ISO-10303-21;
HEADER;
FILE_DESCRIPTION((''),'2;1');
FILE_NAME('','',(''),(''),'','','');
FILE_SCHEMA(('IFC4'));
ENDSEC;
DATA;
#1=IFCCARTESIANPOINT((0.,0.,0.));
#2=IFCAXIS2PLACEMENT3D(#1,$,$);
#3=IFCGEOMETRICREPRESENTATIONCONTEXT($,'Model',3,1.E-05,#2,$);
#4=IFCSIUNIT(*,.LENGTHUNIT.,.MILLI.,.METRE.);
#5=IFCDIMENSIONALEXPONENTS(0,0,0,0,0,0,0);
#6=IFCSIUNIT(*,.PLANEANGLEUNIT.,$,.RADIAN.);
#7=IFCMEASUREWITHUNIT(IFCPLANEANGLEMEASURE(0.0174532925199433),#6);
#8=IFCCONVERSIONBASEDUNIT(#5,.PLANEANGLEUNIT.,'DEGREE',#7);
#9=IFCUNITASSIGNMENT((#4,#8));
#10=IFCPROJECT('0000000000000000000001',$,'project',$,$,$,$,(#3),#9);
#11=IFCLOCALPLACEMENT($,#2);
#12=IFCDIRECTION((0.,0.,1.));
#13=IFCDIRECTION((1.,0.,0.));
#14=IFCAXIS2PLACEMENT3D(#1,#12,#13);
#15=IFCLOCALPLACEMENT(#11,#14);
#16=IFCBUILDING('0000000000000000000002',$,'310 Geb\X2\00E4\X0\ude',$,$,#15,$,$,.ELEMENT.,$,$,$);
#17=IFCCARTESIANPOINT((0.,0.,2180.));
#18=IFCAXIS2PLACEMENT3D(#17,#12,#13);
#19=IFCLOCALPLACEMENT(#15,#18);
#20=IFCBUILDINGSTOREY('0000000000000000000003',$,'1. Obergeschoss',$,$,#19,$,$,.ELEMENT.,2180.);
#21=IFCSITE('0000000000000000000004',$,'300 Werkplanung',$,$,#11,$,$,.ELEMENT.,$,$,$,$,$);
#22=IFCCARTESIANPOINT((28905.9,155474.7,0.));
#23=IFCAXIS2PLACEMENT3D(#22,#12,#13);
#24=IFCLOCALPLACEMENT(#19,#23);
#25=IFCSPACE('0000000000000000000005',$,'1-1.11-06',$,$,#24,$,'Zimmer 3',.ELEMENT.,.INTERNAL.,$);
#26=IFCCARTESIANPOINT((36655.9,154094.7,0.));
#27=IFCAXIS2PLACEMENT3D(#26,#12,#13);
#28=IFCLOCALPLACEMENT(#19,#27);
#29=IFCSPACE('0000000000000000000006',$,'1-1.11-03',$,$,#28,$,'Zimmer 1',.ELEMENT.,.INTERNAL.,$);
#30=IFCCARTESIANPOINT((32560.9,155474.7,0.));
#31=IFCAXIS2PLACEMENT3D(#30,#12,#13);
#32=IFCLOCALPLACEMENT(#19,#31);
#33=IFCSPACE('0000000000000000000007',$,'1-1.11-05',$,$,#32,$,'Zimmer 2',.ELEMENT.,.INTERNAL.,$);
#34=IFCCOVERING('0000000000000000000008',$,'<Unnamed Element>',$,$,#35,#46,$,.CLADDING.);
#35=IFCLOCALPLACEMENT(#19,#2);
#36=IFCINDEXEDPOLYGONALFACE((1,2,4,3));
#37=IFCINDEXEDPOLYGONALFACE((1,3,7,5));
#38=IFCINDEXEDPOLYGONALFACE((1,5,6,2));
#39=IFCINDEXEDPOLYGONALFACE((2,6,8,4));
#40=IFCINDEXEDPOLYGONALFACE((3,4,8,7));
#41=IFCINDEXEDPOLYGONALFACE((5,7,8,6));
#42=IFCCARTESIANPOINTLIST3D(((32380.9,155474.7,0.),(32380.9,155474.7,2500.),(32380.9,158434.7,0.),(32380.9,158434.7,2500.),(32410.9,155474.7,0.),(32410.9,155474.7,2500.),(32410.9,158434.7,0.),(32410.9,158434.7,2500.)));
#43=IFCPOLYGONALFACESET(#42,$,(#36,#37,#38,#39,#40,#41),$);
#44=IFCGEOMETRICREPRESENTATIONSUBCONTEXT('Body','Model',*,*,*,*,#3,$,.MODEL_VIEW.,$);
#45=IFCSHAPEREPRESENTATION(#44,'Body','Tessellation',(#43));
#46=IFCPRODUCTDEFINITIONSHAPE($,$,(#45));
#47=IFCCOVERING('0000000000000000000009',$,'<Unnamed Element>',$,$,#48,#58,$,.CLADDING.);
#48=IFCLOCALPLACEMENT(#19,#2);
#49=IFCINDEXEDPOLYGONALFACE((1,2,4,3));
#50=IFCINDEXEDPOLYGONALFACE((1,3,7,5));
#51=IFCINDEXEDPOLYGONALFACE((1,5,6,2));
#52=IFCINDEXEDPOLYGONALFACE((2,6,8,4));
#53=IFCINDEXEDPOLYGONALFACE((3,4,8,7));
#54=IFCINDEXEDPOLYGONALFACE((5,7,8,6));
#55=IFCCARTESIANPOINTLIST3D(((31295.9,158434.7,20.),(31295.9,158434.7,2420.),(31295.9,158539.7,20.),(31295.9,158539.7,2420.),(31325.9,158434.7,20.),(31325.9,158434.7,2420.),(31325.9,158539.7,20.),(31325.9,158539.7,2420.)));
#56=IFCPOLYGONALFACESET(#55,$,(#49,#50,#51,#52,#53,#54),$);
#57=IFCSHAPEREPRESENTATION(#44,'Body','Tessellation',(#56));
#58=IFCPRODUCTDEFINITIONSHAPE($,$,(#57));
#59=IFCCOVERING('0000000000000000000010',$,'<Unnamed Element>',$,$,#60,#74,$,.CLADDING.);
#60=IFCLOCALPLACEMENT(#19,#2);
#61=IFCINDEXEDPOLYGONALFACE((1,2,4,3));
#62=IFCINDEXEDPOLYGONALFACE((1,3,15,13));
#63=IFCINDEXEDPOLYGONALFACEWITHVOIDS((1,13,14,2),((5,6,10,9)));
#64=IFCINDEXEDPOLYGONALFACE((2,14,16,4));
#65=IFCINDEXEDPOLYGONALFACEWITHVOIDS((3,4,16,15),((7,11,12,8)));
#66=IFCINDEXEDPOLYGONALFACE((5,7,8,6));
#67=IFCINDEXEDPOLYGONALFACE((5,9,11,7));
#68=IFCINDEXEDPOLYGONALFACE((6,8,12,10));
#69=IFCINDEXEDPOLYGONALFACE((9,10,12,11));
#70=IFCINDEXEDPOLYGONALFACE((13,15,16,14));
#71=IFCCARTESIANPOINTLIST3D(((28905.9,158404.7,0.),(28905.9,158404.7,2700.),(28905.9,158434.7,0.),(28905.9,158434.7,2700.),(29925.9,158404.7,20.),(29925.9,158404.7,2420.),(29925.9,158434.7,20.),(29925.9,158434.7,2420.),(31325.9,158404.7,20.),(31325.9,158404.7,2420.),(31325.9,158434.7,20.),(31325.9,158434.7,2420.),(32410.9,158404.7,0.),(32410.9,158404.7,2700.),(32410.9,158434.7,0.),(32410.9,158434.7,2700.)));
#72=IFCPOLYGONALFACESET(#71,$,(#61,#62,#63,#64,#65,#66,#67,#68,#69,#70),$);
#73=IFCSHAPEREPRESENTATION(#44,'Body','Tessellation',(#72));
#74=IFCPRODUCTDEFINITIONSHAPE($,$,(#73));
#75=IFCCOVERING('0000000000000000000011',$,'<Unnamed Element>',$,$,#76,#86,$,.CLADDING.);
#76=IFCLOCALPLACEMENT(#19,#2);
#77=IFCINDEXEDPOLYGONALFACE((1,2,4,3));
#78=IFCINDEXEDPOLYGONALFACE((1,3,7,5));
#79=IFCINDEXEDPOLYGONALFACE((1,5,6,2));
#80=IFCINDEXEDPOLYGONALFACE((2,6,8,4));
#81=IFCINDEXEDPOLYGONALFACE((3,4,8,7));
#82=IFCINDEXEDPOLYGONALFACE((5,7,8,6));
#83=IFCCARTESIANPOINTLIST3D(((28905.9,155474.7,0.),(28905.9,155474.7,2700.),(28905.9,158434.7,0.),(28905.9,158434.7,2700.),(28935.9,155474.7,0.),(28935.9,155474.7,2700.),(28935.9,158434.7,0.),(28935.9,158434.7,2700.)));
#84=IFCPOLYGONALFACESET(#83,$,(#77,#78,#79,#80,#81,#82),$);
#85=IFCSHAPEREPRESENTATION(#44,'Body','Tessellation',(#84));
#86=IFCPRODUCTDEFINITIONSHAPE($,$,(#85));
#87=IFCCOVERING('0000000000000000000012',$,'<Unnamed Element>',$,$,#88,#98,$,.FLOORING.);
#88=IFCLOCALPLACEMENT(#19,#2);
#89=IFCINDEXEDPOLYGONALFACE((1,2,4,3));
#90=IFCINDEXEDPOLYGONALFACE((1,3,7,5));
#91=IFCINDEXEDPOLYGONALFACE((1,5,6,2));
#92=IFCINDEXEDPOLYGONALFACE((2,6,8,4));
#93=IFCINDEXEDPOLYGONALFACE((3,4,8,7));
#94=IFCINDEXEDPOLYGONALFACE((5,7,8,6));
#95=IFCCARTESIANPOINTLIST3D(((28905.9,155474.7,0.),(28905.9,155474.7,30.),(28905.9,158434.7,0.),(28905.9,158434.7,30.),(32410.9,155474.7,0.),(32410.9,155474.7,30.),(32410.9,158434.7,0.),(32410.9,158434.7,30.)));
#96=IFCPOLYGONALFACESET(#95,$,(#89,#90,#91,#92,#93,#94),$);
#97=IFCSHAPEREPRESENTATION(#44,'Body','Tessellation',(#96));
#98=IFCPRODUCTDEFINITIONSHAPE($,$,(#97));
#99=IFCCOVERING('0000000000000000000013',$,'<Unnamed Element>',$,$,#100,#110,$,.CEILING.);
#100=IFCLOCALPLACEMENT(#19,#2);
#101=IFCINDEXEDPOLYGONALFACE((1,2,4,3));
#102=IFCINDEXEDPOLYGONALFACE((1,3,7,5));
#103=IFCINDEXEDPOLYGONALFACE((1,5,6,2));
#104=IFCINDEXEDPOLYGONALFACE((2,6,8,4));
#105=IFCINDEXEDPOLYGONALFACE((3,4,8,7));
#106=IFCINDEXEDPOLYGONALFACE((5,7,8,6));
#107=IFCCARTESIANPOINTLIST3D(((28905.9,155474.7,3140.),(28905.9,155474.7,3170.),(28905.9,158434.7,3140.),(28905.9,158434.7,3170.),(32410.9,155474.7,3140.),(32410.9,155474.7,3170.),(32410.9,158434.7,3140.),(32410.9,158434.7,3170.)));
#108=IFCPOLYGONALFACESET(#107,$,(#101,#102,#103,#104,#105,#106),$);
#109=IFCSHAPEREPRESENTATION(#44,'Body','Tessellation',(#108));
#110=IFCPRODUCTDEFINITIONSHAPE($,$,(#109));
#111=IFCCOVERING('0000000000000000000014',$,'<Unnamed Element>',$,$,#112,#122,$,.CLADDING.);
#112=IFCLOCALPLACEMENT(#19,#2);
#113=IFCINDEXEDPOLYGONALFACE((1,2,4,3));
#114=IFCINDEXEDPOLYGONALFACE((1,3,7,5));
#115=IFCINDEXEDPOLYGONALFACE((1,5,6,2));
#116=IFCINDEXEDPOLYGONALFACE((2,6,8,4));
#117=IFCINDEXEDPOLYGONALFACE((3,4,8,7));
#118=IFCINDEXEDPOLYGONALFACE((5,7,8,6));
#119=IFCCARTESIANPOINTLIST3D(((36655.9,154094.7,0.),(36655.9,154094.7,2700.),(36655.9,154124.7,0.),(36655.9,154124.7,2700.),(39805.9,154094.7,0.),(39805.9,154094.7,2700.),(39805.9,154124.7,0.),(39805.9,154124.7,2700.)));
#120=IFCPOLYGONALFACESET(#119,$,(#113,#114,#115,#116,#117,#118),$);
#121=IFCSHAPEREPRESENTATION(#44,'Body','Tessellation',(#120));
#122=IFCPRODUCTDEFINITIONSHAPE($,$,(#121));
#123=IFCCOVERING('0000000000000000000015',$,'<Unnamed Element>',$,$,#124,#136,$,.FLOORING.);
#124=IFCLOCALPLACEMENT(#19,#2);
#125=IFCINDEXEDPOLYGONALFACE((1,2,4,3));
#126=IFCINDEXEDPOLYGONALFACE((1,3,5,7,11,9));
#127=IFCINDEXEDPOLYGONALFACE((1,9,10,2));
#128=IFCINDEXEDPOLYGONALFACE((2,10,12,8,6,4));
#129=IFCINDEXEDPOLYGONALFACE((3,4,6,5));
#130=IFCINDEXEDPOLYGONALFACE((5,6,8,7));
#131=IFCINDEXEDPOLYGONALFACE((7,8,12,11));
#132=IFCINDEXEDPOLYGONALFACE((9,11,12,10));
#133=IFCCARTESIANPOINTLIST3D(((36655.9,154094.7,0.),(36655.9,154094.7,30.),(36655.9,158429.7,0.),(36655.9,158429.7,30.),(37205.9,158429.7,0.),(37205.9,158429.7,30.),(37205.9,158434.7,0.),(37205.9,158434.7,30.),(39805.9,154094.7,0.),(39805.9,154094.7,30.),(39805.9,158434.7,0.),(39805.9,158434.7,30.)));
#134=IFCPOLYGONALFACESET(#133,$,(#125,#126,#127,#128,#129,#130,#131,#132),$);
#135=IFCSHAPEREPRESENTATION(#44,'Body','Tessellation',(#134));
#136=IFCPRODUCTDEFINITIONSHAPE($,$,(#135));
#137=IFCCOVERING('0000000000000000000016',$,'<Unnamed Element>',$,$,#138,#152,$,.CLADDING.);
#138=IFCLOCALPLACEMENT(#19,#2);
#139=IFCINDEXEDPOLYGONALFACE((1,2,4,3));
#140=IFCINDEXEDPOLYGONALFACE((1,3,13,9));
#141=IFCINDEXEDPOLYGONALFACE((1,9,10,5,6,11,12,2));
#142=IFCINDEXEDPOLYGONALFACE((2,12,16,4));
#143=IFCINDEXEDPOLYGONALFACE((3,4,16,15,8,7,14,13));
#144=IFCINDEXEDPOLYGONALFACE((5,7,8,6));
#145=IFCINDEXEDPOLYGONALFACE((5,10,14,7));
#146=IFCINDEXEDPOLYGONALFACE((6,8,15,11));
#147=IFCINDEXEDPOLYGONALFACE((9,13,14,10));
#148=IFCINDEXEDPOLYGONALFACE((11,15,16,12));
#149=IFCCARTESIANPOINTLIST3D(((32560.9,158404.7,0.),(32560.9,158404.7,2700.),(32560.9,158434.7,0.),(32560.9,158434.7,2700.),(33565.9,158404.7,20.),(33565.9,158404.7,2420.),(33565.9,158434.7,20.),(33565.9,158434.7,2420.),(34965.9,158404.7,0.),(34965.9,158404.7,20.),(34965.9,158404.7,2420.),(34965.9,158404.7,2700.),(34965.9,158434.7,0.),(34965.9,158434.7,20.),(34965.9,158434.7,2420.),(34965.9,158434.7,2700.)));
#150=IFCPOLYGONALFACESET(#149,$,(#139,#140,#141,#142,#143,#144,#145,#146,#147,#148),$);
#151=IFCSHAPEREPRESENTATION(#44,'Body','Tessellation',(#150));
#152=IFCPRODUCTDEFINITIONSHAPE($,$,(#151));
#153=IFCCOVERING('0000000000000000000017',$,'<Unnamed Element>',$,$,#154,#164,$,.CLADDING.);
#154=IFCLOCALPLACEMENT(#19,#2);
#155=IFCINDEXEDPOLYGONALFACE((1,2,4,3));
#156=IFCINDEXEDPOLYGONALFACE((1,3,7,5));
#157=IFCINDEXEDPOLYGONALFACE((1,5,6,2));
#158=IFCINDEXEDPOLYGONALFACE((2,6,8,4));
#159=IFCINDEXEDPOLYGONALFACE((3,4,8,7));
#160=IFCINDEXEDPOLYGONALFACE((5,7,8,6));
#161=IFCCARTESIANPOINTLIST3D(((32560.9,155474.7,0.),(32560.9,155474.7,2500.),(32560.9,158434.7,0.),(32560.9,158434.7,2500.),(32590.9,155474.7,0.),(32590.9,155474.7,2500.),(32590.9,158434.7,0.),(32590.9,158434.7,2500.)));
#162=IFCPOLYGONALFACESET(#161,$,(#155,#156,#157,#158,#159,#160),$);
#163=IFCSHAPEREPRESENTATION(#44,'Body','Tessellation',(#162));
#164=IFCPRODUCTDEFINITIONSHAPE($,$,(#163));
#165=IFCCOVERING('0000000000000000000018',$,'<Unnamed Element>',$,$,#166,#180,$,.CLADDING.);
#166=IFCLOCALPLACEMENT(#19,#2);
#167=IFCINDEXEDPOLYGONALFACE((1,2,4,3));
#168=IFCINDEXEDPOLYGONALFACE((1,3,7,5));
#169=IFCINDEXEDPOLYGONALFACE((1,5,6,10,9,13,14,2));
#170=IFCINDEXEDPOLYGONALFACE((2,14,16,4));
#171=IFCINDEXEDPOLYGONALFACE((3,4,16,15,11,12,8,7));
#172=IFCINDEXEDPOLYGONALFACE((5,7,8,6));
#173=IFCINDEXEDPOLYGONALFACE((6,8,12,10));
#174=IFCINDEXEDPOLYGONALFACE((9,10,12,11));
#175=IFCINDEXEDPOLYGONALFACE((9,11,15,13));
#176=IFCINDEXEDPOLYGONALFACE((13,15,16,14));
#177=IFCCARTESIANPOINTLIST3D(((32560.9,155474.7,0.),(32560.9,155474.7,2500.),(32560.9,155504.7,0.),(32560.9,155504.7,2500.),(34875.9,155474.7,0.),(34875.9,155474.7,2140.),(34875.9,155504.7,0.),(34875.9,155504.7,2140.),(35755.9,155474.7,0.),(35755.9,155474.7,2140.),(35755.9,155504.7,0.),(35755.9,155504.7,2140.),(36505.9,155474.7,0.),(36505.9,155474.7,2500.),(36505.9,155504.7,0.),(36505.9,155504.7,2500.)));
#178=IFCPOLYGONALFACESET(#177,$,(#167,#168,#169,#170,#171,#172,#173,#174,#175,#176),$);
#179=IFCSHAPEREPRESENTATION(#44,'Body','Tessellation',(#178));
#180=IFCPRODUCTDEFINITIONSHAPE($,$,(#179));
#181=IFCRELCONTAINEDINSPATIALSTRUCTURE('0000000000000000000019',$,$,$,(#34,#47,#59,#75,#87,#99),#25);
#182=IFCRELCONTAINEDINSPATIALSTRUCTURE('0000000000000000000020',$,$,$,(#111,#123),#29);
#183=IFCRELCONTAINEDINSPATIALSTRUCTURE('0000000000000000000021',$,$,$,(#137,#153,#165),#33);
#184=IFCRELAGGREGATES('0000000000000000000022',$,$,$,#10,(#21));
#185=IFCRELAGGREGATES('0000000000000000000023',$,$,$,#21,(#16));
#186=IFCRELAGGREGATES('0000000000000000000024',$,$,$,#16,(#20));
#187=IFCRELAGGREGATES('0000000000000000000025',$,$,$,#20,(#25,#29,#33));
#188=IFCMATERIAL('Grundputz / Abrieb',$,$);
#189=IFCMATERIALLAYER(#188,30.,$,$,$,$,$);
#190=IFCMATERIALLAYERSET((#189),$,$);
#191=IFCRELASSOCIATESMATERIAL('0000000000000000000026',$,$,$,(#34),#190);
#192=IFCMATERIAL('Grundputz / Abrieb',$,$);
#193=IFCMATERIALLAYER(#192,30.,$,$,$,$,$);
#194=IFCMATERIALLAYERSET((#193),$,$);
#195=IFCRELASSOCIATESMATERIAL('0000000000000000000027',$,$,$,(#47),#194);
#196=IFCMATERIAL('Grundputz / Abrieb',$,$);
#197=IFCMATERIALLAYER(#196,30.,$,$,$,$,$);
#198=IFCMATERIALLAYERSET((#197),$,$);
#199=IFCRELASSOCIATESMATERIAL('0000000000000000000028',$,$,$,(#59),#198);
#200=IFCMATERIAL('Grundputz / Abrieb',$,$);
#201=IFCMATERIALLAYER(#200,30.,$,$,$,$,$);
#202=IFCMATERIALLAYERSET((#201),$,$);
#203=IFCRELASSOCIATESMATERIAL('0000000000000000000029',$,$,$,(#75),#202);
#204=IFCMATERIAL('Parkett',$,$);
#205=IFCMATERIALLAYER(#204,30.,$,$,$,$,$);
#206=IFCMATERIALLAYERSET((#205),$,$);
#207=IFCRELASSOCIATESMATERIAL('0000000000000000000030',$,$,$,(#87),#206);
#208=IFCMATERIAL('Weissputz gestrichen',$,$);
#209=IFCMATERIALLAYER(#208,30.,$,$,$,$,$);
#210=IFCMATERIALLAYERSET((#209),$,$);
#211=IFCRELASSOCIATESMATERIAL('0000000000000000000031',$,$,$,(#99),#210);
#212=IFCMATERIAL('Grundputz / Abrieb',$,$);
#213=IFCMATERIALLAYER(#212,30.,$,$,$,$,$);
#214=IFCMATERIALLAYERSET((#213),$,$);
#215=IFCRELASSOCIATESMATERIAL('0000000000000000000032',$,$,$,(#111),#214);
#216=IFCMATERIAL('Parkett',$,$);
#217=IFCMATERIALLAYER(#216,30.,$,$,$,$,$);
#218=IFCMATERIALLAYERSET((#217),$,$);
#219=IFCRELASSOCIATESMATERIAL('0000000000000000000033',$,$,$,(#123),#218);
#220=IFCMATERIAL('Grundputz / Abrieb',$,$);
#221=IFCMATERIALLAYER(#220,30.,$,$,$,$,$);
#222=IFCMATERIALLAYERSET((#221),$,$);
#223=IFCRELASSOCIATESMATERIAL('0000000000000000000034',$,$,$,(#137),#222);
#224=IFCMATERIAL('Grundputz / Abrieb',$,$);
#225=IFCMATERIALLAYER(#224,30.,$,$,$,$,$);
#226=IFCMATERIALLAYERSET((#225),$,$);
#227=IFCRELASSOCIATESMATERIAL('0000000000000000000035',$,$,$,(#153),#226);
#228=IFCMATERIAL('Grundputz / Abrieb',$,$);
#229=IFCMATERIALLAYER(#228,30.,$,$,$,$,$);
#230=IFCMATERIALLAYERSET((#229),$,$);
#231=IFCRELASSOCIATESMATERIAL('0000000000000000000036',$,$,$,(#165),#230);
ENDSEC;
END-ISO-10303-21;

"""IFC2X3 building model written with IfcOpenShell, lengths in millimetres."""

from ifc_helpers import new_model, entity, si_unit, converted_unit, frame, frame_2d, origin, origin_with_axes, place, context, subcontext, project, spatial, polyline, rectangle, outline, extrude, material, layer, layer_set, layer_usage, element, save


model = new_model("IFC2X3")

# Units and contexts
model_context = context("Model", 3, precision=1e-05, world=origin())
body_context = subcontext(model_context, "Body", "Model", "MODEL_VIEW")
ifc_project = project(units=[si_unit("LENGTHUNIT", "METRE", prefix="MILLI"), converted_unit("PLANEANGLEUNIT", "DEGREE", entity("IfcPlaneAngleMeasure", 0.0174532925199433), si_unit("PLANEANGLEUNIT", "RADIAN"), dimensions=[0, 0, 0, 0, 0, 0, 0])], contexts=[model_context])

# Site, building, storey
site_placement = place(None, origin())
site = spatial("IfcSite", under=ifc_project, at=site_placement, Name="300 Werkplanung", CompositionType="ELEMENT")
building_placement = place(site_placement, origin_with_axes())
building = spatial("IfcBuilding", under=site, at=building_placement, Name="310 Gebäude", CompositionType="ELEMENT")
storey_placement = place(building_placement, frame((0.0, 0.0, 2180.0), z_axis=(0.0, 0.0, 1.0), x_axis=(1.0, 0.0, 0.0)))
storey = spatial("IfcBuildingStorey", under=building, at=storey_placement, Name="1. Obergeschoss", CompositionType="ELEMENT", Elevation=2180.0)

# Shared definitions
space_1_placement = place(storey_placement, frame((28905.9, 155474.7, 0.0), z_axis=(0.0, 0.0, 1.0), x_axis=(1.0, 0.0, 0.0)))
space_1 = spatial("IfcSpace", under=storey, at=space_1_placement, Name="1-1.11-06", LongName="Zimmer 3", CompositionType="ELEMENT", InteriorOrExteriorSpace="INTERNAL")

# Coverings
ifc_material_1 = material(Name="Grundputz / Abrieb")
ifc_layer_1 = layer(ifc_material_1, 30.0)
ifc_layer_set_1 = layer_set([ifc_layer_1])
ifc_layer_usage_1 = layer_usage(ifc_layer_set_1, "AXIS3", "POSITIVE", 0.0)
covering_1_placement = place(space_1_placement, frame((3505.0, 0.0, 0.0), z_axis=(0.0, 0.0, 1.0), x_axis=(0.0, 1.0, 0.0)))
element("IfcCovering", 1, at=covering_1_placement, inside=space_1, material=ifc_layer_usage_1, Name="<Unnamed Element>", PredefinedType="CLADDING", context=body_context, shape_type="SweptSolid", body=[
    extrude(rectangle(XDim=2500.0, YDim=2960.0, at=frame_2d((-1480.0, 1250.0), x_axis=(0.0, 1.0))), frame((2960.0, 0.0, 2500.0), z_axis=(0.0, 1.0, 0.0), x_axis=(1.0, 0.0, 0.0)), (0.0, 0.0, 1.0), 30.0),
])
ifc_material_2 = material(Name="Grundputz / Abrieb")
ifc_layer_2 = layer(ifc_material_2, 30.0)
ifc_layer_set_2 = layer_set([ifc_layer_2])
ifc_layer_usage_2 = layer_usage(ifc_layer_set_2, "AXIS3", "POSITIVE", 0.0)
covering_2_placement = place(space_1_placement, frame((2420.0, 2960.0, 20.0), z_axis=(0.0, 0.0, 1.0), x_axis=(0.0, 1.0, 0.0)))
element("IfcCovering", 2, at=covering_2_placement, inside=space_1, material=ifc_layer_usage_2, Name="<Unnamed Element>", PredefinedType="CLADDING", context=body_context, shape_type="SweptSolid", body=[
    extrude(rectangle(XDim=2400.0, YDim=105.0, at=frame_2d((-52.5, 1200.0), x_axis=(0.0, 1.0))), frame((105.0, 0.0, 2400.0), z_axis=(0.0, 1.0, 0.0), x_axis=(1.0, 0.0, 0.0)), (0.0, 0.0, 1.0), 30.0),
])
ifc_material_3 = material(Name="Grundputz / Abrieb")
ifc_layer_3 = layer(ifc_material_3, 30.0)
ifc_layer_set_3 = layer_set([ifc_layer_3])
ifc_layer_usage_3 = layer_usage(ifc_layer_set_3, "AXIS3", "POSITIVE", 0.0)
covering_3_placement = place(space_1_placement, frame((3505.0, 2960.0, 0.0), z_axis=(0.0, 0.0, 1.0), x_axis=(-1.0, 0.0, 0.0)))
element("IfcCovering", 3, at=covering_3_placement, inside=space_1, material=ifc_layer_usage_3, Name="<Unnamed Element>", PredefinedType="CLADDING", context=body_context, shape_type="SweptSolid", body=[
    extrude(outline(polyline([(3505.0, 0.0), (3505.0, -2700.0), (0.0, -2700.0), (0.0, 0.0), (3505.0, 0.0)]), holes=[polyline([(2485.0, -20.0), (1085.0, -20.0), (1085.0, -2420.0), (2485.0, -2420.0), (2485.0, -20.0)])]), frame((0.0, 0.0, 0.0), z_axis=(0.0, 1.0, 0.0), x_axis=(1.0, 0.0, 0.0)), (0.0, 0.0, 1.0), 30.0),
])
ifc_material_4 = material(Name="Grundputz / Abrieb")
ifc_layer_4 = layer(ifc_material_4, 30.0)
ifc_layer_set_4 = layer_set([ifc_layer_4])
ifc_layer_usage_4 = layer_usage(ifc_layer_set_4, "AXIS3", "POSITIVE", 0.0)
covering_4_placement = place(space_1_placement, frame((0.0, 2960.0, 0.0), z_axis=(0.0, 0.0, 1.0), x_axis=(0.0, -1.0, 0.0)))
element("IfcCovering", 4, at=covering_4_placement, inside=space_1, material=ifc_layer_usage_4, Name="<Unnamed Element>", PredefinedType="CLADDING", context=body_context, shape_type="SweptSolid", body=[
    extrude(rectangle(XDim=2700.0, YDim=2960.0, at=frame_2d((-1480.0, 1350.0), x_axis=(0.0, 1.0))), frame((2960.0, 0.0, 2700.0), z_axis=(0.0, 1.0, 0.0), x_axis=(1.0, 0.0, 0.0)), (0.0, 0.0, 1.0), 30.0),
])
ifc_material_5 = material(Name="Parkett")
ifc_layer_5 = layer(ifc_material_5, 30.0)
ifc_layer_set_5 = layer_set([ifc_layer_5])
ifc_layer_usage_5 = layer_usage(ifc_layer_set_5, "AXIS3", "POSITIVE", 0.0)
covering_5_placement = place(space_1_placement, origin_with_axes())
element("IfcCovering", 5, at=covering_5_placement, inside=space_1, material=ifc_layer_usage_5, Name="<Unnamed Element>", PredefinedType="FLOORING", context=body_context, shape_type="SweptSolid", body=[
    extrude(rectangle(XDim=3505.0, YDim=2960.0, at=frame_2d((-1752.5, -1480.0), x_axis=(-1.0, 0.0))), frame((3505.0, 2960.0, 0.0), z_axis=(0.0, 0.0, 1.0), x_axis=(1.0, 0.0, 0.0)), (0.0, 0.0, 1.0), 30.0),
])
ifc_material_6 = material(Name="Weissputz gestrichen")
ifc_layer_6 = layer(ifc_material_6, 30.0)
ifc_layer_set_6 = layer_set([ifc_layer_6])
ifc_layer_usage_6 = layer_usage(ifc_layer_set_6, "AXIS3", "POSITIVE", 0.0)
covering_6_placement = place(space_1_placement, frame((1752.5, 1480.0, 3170.0), z_axis=(0.0, 0.0, -1.0), x_axis=(1.0, 0.0, 0.0)))
element("IfcCovering", 6, at=covering_6_placement, inside=space_1, material=ifc_layer_usage_6, Name="<Unnamed Element>", PredefinedType="CEILING", context=body_context, shape_type="SweptSolid", body=[
    extrude(rectangle(XDim=3505.0, YDim=2960.0, at=frame_2d((1752.5, 1480.0), x_axis=(1.0, 0.0))), frame((-1752.5, -1480.0, 0.0), z_axis=(0.0, 0.0, 1.0), x_axis=(1.0, 0.0, 0.0)), (0.0, 0.0, 1.0), 30.0),
])

# Shared definitions
space_2_placement = place(storey_placement, frame((36655.9, 154094.7, 0.0), z_axis=(0.0, 0.0, 1.0), x_axis=(1.0, 0.0, 0.0)))
space_2 = spatial("IfcSpace", under=storey, at=space_2_placement, Name="1-1.11-03", LongName="Zimmer 1", CompositionType="ELEMENT", InteriorOrExteriorSpace="INTERNAL")

# Coverings
ifc_material_7 = material(Name="Grundputz / Abrieb")
ifc_layer_7 = layer(ifc_material_7, 30.0)
ifc_layer_set_7 = layer_set([ifc_layer_7])
ifc_layer_usage_7 = layer_usage(ifc_layer_set_7, "AXIS3", "POSITIVE", 0.0)
covering_7_placement = place(space_2_placement, frame((0.0, 0.0, 0.0), z_axis=(0.0, 0.0, 1.0), x_axis=(1.0, 0.0, 0.0)))
element("IfcCovering", 7, at=covering_7_placement, inside=space_2, material=ifc_layer_usage_7, Name="<Unnamed Element>", PredefinedType="CLADDING", context=body_context, shape_type="SweptSolid", body=[
    extrude(rectangle(XDim=2700.0, YDim=3150.0, at=frame_2d((-1575.0, 1350.0), x_axis=(0.0, 1.0))), frame((3150.0, 0.0, 2700.0), z_axis=(0.0, 1.0, 0.0), x_axis=(1.0, 0.0, 0.0)), (0.0, 0.0, 1.0), 30.0),
])
ifc_material_8 = material(Name="Parkett")
ifc_layer_8 = layer(ifc_material_8, 30.0)
ifc_layer_set_8 = layer_set([ifc_layer_8])
ifc_layer_usage_8 = layer_usage(ifc_layer_set_8, "AXIS3", "POSITIVE", 0.0)
covering_8_placement = place(space_2_placement, origin_with_axes())
element("IfcCovering", 8, at=covering_8_placement, inside=space_2, material=ifc_layer_usage_8, Name="<Unnamed Element>", PredefinedType="FLOORING", context=body_context, shape_type="SweptSolid", body=[
    extrude(outline(polyline([(0.0, 4335.0), (0.0, 0.0), (3150.0, 0.0), (3150.0, 4340.0), (550.0, 4340.0), (550.0, 4335.0), (0.0, 4335.0)])), origin_with_axes(), (0.0, 0.0, 1.0), 30.0),
])

# Shared definitions
space_3_placement = place(storey_placement, frame((32560.9, 155474.7, 0.0), z_axis=(0.0, 0.0, 1.0), x_axis=(1.0, 0.0, 0.0)))
space_3 = spatial("IfcSpace", under=storey, at=space_3_placement, Name="1-1.11-05", LongName="Zimmer 2", CompositionType="ELEMENT", InteriorOrExteriorSpace="INTERNAL")

# Coverings
ifc_material_9 = material(Name="Grundputz / Abrieb")
ifc_layer_9 = layer(ifc_material_9, 30.0)
ifc_layer_set_9 = layer_set([ifc_layer_9])
ifc_layer_usage_9 = layer_usage(ifc_layer_set_9, "AXIS3", "POSITIVE", 0.0)
covering_9_placement = place(space_3_placement, frame((2405.0, 2960.0, 0.0), z_axis=(0.0, 0.0, 1.0), x_axis=(-1.0, 0.0, 0.0)))
element("IfcCovering", 9, at=covering_9_placement, inside=space_3, material=ifc_layer_usage_9, Name="<Unnamed Element>", PredefinedType="CLADDING", context=body_context, shape_type="SweptSolid", body=[
    extrude(outline(polyline([(2405.0, 0.0), (2405.0, -2700.0), (0.0, -2700.0), (0.0, -2420.0), (1400.0, -2420.0), (1400.0, -20.0), (0.0, -20.0), (0.0, 0.0), (2405.0, 0.0)])), frame((0.0, 0.0, 0.0), z_axis=(0.0, 1.0, 0.0), x_axis=(1.0, 0.0, 0.0)), (0.0, 0.0, 1.0), 30.0),
])
ifc_material_10 = material(Name="Grundputz / Abrieb")
ifc_layer_10 = layer(ifc_material_10, 30.0)
ifc_layer_set_10 = layer_set([ifc_layer_10])
ifc_layer_usage_10 = layer_usage(ifc_layer_set_10, "AXIS3", "POSITIVE", 0.0)
covering_10_placement = place(space_3_placement, frame((0.0, 2960.0, 0.0), z_axis=(0.0, 0.0, 1.0), x_axis=(0.0, -1.0, 0.0)))
element("IfcCovering", 10, at=covering_10_placement, inside=space_3, material=ifc_layer_usage_10, Name="<Unnamed Element>", PredefinedType="CLADDING", context=body_context, shape_type="SweptSolid", body=[
    extrude(rectangle(XDim=2500.0, YDim=2960.0, at=frame_2d((-1480.0, 1250.0), x_axis=(0.0, 1.0))), frame((2960.0, 0.0, 2500.0), z_axis=(0.0, 1.0, 0.0), x_axis=(1.0, 0.0, 0.0)), (0.0, 0.0, 1.0), 30.0),
])
ifc_material_11 = material(Name="Grundputz / Abrieb")
ifc_layer_11 = layer(ifc_material_11, 30.0)
ifc_layer_set_11 = layer_set([ifc_layer_11])
ifc_layer_usage_11 = layer_usage(ifc_layer_set_11, "AXIS3", "POSITIVE", 0.0)
covering_11_placement = place(space_3_placement, origin_with_axes())
element("IfcCovering", 11, at=covering_11_placement, inside=space_3, material=ifc_layer_usage_11, Name="<Unnamed Element>", PredefinedType="CLADDING", context=body_context, shape_type="SweptSolid", body=[
    extrude(outline(polyline([(3945.0, 0.0), (3945.0, -2500.0), (0.0, -2500.0), (0.0, 0.0), (2315.0, 0.0), (2315.0, -2140.0), (3195.0, -2140.0), (3195.0, 0.0), (3945.0, 0.0)])), frame((0.0, 0.0, 0.0), z_axis=(0.0, 1.0, 0.0), x_axis=(1.0, 0.0, 0.0)), (0.0, 0.0, 1.0), 30.0),
])

save(model, "model.ifc")
